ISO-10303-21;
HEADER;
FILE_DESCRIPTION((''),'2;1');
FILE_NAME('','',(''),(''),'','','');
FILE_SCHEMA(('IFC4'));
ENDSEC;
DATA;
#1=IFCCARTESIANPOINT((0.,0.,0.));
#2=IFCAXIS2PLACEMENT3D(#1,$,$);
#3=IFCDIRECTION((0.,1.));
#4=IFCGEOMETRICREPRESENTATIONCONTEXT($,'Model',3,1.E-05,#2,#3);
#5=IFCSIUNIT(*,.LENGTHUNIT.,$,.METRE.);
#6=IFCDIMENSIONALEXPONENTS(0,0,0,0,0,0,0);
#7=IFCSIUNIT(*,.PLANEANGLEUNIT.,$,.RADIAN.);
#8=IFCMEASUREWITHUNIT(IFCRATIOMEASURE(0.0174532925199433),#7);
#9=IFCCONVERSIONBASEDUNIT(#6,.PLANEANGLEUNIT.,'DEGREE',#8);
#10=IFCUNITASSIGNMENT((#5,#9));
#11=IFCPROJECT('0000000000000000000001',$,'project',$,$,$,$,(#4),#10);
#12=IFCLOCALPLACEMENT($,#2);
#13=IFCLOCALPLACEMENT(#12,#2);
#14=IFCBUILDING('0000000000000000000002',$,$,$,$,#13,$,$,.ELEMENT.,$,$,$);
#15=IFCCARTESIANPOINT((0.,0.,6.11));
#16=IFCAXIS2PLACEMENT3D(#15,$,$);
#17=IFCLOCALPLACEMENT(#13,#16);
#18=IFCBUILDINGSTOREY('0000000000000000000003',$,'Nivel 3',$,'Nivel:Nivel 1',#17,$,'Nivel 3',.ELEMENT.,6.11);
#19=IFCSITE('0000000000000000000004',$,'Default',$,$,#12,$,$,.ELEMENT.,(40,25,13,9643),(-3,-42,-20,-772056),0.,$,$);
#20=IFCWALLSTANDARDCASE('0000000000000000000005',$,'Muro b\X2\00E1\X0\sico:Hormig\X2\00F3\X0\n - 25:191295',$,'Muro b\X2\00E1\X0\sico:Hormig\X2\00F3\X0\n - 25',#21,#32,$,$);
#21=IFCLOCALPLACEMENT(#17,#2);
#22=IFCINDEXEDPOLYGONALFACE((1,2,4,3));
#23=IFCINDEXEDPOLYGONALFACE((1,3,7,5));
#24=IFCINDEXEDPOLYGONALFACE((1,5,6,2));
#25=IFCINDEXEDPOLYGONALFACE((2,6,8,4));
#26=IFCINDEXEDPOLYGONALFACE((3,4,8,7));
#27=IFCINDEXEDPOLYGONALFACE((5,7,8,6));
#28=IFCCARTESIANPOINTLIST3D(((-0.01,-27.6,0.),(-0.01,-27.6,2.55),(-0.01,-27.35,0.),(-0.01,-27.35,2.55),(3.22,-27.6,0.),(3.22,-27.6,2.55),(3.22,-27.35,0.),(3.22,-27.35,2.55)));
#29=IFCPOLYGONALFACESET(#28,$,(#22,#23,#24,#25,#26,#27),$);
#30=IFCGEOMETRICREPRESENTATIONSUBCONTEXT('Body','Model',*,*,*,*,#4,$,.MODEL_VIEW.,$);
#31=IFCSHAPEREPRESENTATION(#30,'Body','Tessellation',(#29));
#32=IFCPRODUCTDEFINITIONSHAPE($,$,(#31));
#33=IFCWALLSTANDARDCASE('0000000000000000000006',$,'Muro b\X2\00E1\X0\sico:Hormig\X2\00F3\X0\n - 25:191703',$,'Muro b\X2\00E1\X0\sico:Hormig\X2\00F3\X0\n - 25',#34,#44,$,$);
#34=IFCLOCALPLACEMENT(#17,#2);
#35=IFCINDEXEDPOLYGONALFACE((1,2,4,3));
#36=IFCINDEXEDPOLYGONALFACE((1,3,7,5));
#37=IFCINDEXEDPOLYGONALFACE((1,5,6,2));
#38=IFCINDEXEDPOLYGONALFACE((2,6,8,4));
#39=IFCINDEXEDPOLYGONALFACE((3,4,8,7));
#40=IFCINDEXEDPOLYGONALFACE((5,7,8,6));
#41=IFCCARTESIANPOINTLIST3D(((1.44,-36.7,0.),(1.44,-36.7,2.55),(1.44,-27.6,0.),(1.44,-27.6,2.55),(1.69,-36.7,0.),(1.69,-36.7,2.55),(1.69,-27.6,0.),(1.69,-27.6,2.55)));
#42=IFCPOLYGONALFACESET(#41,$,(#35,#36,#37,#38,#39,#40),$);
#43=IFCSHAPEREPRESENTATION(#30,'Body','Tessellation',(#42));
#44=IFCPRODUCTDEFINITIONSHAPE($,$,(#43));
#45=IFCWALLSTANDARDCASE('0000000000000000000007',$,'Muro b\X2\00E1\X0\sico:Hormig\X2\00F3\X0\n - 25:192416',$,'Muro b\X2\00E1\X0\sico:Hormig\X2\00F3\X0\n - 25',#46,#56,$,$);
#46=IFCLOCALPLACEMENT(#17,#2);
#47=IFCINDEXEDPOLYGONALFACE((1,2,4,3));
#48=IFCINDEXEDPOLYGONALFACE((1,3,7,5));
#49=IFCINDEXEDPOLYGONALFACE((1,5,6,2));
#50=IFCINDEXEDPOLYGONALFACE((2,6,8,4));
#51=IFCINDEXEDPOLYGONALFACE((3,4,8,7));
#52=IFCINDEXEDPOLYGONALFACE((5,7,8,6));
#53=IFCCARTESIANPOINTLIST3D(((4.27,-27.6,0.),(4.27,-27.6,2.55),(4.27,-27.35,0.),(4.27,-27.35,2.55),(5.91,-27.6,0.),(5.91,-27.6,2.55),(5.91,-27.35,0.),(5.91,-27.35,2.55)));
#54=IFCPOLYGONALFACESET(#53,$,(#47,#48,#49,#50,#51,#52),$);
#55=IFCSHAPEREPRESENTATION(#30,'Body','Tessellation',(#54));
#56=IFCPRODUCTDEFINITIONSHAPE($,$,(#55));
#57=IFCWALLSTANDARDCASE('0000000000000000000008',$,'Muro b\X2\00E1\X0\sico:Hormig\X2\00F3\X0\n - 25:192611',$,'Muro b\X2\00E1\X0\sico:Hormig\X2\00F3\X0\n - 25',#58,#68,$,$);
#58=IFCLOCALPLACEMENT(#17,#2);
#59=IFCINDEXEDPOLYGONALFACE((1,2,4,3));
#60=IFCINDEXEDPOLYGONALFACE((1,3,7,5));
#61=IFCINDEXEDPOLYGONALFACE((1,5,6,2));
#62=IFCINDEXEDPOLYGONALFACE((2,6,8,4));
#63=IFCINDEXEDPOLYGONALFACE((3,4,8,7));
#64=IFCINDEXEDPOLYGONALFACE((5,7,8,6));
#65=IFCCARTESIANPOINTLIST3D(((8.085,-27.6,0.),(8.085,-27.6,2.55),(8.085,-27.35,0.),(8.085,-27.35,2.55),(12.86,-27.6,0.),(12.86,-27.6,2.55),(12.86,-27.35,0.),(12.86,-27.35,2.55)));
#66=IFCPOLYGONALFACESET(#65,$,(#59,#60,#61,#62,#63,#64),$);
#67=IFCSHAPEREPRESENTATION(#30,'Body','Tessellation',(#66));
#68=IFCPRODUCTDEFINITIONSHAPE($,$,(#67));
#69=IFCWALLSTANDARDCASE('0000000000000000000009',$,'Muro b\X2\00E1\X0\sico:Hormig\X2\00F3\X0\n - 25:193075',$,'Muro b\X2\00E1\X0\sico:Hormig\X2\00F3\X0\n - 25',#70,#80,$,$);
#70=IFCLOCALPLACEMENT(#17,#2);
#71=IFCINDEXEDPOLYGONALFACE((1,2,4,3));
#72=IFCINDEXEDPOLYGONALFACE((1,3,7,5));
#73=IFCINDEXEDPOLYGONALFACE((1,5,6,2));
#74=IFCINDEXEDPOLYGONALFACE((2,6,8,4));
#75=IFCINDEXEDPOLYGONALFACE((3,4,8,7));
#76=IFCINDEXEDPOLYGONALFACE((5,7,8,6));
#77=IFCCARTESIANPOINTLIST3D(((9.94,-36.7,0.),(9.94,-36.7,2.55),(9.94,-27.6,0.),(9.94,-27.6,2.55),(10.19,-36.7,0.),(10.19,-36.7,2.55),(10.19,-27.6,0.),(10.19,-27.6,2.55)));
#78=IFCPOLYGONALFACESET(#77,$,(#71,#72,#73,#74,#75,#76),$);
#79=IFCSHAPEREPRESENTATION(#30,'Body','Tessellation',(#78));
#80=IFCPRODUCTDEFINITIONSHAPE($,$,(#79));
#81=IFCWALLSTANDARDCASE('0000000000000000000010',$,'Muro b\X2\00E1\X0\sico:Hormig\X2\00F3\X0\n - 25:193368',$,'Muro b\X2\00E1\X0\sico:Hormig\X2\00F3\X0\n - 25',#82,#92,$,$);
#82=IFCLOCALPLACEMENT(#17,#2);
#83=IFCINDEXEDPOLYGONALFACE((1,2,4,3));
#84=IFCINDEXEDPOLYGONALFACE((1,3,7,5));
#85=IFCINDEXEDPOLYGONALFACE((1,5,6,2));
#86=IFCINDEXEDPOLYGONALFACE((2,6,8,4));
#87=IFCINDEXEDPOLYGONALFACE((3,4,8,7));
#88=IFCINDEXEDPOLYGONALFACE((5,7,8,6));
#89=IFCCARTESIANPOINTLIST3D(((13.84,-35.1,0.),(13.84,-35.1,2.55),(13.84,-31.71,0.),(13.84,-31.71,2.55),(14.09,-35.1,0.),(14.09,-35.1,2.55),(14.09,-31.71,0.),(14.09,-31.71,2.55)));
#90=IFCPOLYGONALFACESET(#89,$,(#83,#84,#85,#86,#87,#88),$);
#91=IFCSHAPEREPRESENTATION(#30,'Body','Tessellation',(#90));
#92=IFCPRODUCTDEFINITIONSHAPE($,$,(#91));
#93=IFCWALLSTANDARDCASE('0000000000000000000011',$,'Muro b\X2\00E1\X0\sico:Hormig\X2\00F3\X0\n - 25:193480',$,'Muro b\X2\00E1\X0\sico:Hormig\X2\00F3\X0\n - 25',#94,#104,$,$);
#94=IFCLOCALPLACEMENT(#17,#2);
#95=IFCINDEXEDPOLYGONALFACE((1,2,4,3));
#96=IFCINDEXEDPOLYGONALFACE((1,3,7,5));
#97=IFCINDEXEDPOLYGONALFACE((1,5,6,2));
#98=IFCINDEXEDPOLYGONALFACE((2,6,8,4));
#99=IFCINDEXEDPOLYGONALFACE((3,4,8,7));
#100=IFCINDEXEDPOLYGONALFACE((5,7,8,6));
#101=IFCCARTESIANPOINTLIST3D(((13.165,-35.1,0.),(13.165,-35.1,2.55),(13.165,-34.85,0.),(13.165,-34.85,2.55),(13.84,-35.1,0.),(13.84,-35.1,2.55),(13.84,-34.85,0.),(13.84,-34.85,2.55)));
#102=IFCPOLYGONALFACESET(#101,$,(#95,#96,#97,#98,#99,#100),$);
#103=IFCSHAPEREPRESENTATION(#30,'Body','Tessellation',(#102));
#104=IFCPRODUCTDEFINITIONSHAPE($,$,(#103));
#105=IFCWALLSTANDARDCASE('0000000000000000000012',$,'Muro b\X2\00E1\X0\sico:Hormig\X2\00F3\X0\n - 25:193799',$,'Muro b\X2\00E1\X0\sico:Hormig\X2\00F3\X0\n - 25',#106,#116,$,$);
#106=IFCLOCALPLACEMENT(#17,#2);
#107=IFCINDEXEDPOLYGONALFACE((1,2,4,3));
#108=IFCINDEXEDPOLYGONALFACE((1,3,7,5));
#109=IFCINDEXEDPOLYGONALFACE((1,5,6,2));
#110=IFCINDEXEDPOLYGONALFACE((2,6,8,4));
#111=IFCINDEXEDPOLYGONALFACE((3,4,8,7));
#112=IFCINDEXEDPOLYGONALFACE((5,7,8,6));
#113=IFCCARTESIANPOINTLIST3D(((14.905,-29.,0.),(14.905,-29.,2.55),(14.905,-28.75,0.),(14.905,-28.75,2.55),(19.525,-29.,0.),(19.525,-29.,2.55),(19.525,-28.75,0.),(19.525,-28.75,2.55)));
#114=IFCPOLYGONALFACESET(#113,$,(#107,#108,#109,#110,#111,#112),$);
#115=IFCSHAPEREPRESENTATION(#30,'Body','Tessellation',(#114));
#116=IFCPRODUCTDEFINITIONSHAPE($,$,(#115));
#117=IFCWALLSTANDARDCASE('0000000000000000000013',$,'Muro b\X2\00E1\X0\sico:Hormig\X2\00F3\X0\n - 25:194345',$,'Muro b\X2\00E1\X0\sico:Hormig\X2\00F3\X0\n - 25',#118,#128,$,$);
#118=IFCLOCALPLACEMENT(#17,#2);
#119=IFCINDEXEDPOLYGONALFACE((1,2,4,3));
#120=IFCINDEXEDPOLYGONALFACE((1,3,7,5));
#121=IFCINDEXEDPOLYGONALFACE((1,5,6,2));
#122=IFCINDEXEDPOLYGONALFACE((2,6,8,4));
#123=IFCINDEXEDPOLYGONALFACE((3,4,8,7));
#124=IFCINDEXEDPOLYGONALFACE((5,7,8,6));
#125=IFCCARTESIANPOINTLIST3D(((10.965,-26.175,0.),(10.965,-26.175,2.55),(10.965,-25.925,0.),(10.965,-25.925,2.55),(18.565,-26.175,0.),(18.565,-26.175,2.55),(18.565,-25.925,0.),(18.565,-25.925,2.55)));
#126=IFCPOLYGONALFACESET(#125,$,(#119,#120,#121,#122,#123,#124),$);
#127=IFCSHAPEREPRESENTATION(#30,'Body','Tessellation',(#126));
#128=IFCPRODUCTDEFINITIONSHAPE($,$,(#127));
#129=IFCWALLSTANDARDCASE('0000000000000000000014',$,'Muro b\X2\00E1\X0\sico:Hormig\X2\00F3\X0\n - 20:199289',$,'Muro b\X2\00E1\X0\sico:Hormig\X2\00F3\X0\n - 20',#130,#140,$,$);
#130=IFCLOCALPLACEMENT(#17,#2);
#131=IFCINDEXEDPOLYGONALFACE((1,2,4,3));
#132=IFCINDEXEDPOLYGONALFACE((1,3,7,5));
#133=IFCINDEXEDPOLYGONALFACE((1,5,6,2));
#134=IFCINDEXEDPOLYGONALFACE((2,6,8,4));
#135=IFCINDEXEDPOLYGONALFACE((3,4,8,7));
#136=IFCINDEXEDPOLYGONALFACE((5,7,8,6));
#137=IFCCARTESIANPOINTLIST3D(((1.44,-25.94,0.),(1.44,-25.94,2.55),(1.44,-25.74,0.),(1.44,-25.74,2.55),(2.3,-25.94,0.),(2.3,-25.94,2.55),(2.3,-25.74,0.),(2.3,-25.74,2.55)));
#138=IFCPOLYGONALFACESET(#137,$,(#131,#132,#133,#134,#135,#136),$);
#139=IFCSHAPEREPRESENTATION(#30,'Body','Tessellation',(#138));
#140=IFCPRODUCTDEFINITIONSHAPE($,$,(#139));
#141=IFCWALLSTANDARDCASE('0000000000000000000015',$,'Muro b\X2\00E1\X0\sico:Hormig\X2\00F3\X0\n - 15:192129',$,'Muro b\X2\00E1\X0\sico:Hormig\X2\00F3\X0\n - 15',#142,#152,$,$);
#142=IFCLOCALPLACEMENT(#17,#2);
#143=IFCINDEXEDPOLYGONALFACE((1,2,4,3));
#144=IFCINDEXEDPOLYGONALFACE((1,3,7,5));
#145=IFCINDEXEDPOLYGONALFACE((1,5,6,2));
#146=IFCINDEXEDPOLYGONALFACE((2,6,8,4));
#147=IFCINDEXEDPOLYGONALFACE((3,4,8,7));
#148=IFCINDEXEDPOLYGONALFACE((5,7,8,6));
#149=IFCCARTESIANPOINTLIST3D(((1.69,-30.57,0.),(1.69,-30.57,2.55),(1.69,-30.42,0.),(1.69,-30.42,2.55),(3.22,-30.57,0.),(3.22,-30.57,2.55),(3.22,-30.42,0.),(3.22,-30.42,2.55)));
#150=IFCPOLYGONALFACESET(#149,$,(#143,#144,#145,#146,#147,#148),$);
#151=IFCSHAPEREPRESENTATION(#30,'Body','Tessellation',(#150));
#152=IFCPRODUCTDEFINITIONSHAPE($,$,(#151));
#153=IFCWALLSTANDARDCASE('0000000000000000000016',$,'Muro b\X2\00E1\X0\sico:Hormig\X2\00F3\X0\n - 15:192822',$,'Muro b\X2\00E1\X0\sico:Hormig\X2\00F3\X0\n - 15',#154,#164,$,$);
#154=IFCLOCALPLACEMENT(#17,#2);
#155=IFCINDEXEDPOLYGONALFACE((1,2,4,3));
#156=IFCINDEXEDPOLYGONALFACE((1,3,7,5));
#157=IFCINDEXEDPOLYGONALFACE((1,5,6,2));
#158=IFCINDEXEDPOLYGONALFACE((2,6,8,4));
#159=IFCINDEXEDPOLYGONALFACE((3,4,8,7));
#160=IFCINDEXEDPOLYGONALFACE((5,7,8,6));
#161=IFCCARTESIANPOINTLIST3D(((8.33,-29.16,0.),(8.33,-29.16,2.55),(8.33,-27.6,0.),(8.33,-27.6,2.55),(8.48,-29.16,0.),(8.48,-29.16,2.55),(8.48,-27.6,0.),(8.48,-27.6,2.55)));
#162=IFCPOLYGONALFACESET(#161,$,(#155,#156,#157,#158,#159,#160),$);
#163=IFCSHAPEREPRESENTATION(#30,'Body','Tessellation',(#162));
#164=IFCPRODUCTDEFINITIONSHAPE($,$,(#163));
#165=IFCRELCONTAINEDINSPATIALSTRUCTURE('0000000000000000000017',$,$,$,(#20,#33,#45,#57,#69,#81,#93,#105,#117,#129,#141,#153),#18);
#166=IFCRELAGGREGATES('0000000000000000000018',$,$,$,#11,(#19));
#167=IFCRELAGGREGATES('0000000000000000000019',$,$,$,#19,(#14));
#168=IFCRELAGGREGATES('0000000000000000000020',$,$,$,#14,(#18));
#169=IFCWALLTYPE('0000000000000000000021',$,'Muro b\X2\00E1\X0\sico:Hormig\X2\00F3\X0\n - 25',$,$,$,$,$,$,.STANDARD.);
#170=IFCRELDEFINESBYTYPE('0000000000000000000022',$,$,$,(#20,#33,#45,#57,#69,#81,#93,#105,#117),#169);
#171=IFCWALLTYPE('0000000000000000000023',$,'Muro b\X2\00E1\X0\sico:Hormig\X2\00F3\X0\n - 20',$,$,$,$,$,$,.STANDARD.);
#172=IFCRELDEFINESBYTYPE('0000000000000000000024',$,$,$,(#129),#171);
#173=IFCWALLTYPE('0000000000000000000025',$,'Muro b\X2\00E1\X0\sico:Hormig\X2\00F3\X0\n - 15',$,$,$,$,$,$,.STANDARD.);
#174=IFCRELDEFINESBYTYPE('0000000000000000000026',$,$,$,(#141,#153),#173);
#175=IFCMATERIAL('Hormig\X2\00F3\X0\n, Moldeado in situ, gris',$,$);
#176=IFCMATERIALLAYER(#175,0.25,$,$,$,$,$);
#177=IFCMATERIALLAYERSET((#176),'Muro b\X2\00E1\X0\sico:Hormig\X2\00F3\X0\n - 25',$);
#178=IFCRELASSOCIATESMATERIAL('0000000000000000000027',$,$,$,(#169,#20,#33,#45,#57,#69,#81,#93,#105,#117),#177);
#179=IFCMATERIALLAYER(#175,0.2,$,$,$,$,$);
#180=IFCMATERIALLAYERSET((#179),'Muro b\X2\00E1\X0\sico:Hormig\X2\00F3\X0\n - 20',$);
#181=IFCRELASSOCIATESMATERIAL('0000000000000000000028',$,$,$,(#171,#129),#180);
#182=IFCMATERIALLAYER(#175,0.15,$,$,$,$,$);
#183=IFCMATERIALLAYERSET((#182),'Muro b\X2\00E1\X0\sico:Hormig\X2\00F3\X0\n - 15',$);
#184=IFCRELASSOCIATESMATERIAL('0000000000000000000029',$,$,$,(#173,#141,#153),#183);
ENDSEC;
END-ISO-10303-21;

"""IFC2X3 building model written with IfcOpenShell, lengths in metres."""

from ifc_helpers import new_model, entity, si_unit, converted_unit, direction, frame, frame_2d, origin, place, context, subcontext, project, spatial, rectangle, extrude, material, layer, layer_set, layer_usage, type_object, element, save


model = new_model("IFC2X3")

# Units and contexts
model_context = context("Model", 3, precision=1e-05, world=origin(), true_north=direction((0.0, 1.0)))
body_context = subcontext(model_context, "Body", "Model", "MODEL_VIEW")
ifc_project = project(units=[si_unit("LENGTHUNIT", "METRE"), converted_unit("PLANEANGLEUNIT", "DEGREE", entity("IfcRatioMeasure", 0.0174532925199433), si_unit("PLANEANGLEUNIT", "RADIAN"), dimensions=[0, 0, 0, 0, 0, 0, 0])], contexts=[model_context])

# Site, building, storey
site_placement = place(None, origin())
site = spatial("IfcSite", under=ifc_project, at=site_placement, Name="Default", CompositionType="ELEMENT", RefLatitude=(40, 25, 13, 9643), RefLongitude=(-3, -42, -20, -772056), RefElevation=0.0)
building_placement = place(site_placement, origin())
building = spatial("IfcBuilding", under=site, at=building_placement, CompositionType="ELEMENT")
storey_placement = place(building_placement, frame((0.0, 0.0, 6.11)))
storey = spatial("IfcBuildingStorey", under=building, at=storey_placement, Name="Nivel 3", ObjectType="Nivel:Nivel 1", LongName="Nivel 3", CompositionType="ELEMENT", Elevation=6.11)

# Walls
ifc_material = material(Name="Hormigón, Moldeado in situ, gris")
ifc_layer_1 = layer(ifc_material, 0.25)
ifc_layer_set_1 = layer_set([ifc_layer_1], Name="Muro básico:Hormigón - 25")
wall_type_1 = type_object("IfcWallType", Name="Muro básico:Hormigón - 25", PredefinedType="STANDARD", material=ifc_layer_set_1)
ifc_layer_usage_1 = layer_usage(ifc_layer_set_1, "AXIS2", "NEGATIVE", 0.125)
wall_1_placement = place(storey_placement, frame((-0.01, -27.475, 0.0)))
element("IfcWallStandardCase", 1, at=wall_1_placement, inside=storey, type_object=wall_type_1, material=ifc_layer_usage_1, Name="Muro básico:Hormigón - 25:191295", ObjectType="Muro básico:Hormigón - 25", context=body_context, shape_type="SweptSolid", body=[
    extrude(rectangle(XDim=3.23, YDim=0.25, at=frame_2d((1.615, 0.0), x_axis=(-1.0, 0.0))), origin(), (0.0, 0.0, 1.0), 2.55),
])
ifc_layer_usage_2 = layer_usage(ifc_layer_set_1, "AXIS2", "NEGATIVE", 0.125)
wall_2_placement = place(storey_placement, frame((1.565, -27.6, 0.0), z_axis=(0.0, 0.0, 1.0), x_axis=(0.0, -1.0, 0.0)))
element("IfcWallStandardCase", 2, at=wall_2_placement, inside=storey, type_object=wall_type_1, material=ifc_layer_usage_2, Name="Muro básico:Hormigón - 25:191703", ObjectType="Muro básico:Hormigón - 25", context=body_context, shape_type="SweptSolid", body=[
    extrude(rectangle(XDim=9.1, YDim=0.25, at=frame_2d((4.55, 0.0), x_axis=(-1.0, 0.0))), origin(), (0.0, 0.0, 1.0), 2.55),
])
ifc_layer_usage_3 = layer_usage(ifc_layer_set_1, "AXIS2", "NEGATIVE", 0.125)
wall_3_placement = place(storey_placement, frame((4.27, -27.475, 0.0)))
element("IfcWallStandardCase", 3, at=wall_3_placement, inside=storey, type_object=wall_type_1, material=ifc_layer_usage_3, Name="Muro básico:Hormigón - 25:192416", ObjectType="Muro básico:Hormigón - 25", context=body_context, shape_type="SweptSolid", body=[
    extrude(rectangle(XDim=1.64, YDim=0.25, at=frame_2d((0.82, 0.0), x_axis=(-1.0, 0.0))), origin(), (0.0, 0.0, 1.0), 2.55),
])
ifc_layer_usage_4 = layer_usage(ifc_layer_set_1, "AXIS2", "NEGATIVE", 0.125)
wall_4_placement = place(storey_placement, frame((8.085, -27.475, 0.0)))
element("IfcWallStandardCase", 4, at=wall_4_placement, inside=storey, type_object=wall_type_1, material=ifc_layer_usage_4, Name="Muro básico:Hormigón - 25:192611", ObjectType="Muro básico:Hormigón - 25", context=body_context, shape_type="SweptSolid", body=[
    extrude(rectangle(XDim=4.775, YDim=0.25, at=frame_2d((2.3875, 0.0), x_axis=(-1.0, 0.0))), origin(), (0.0, 0.0, 1.0), 2.55),
])
ifc_layer_usage_5 = layer_usage(ifc_layer_set_1, "AXIS2", "NEGATIVE", 0.125)
wall_5_placement = place(storey_placement, frame((10.065, -27.6, 0.0), z_axis=(0.0, 0.0, 1.0), x_axis=(0.0, -1.0, 0.0)))
element("IfcWallStandardCase", 5, at=wall_5_placement, inside=storey, type_object=wall_type_1, material=ifc_layer_usage_5, Name="Muro básico:Hormigón - 25:193075", ObjectType="Muro básico:Hormigón - 25", context=body_context, shape_type="SweptSolid", body=[
    extrude(rectangle(XDim=9.1, YDim=0.25, at=frame_2d((4.55, 0.0), x_axis=(-1.0, 0.0))), origin(), (0.0, 0.0, 1.0), 2.55),
])
ifc_layer_usage_6 = layer_usage(ifc_layer_set_1, "AXIS2", "NEGATIVE", 0.125)
wall_6_placement = place(storey_placement, frame((13.965, -31.71, 0.0), z_axis=(0.0, 0.0, 1.0), x_axis=(0.0, -1.0, 0.0)))
element("IfcWallStandardCase", 6, at=wall_6_placement, inside=storey, type_object=wall_type_1, material=ifc_layer_usage_6, Name="Muro básico:Hormigón - 25:193368", ObjectType="Muro básico:Hormigón - 25", context=body_context, shape_type="SweptSolid", body=[
    extrude(rectangle(XDim=3.39, YDim=0.25, at=frame_2d((1.695, 0.0), x_axis=(-1.0, 0.0))), origin(), (0.0, 0.0, 1.0), 2.55),
])
ifc_layer_usage_7 = layer_usage(ifc_layer_set_1, "AXIS2", "NEGATIVE", 0.125)
wall_7_placement = place(storey_placement, frame((13.165, -34.975, 0.0)))
element("IfcWallStandardCase", 7, at=wall_7_placement, inside=storey, type_object=wall_type_1, material=ifc_layer_usage_7, Name="Muro básico:Hormigón - 25:193480", ObjectType="Muro básico:Hormigón - 25", context=body_context, shape_type="SweptSolid", body=[
    extrude(rectangle(XDim=0.675, YDim=0.25, at=frame_2d((0.3375, 0.0), x_axis=(-1.0, 0.0))), origin(), (0.0, 0.0, 1.0), 2.55),
])
ifc_layer_usage_8 = layer_usage(ifc_layer_set_1, "AXIS2", "NEGATIVE", 0.125)
wall_8_placement = place(storey_placement, frame((14.905, -28.875, 0.0)))
element("IfcWallStandardCase", 8, at=wall_8_placement, inside=storey, type_object=wall_type_1, material=ifc_layer_usage_8, Name="Muro básico:Hormigón - 25:193799", ObjectType="Muro básico:Hormigón - 25", context=body_context, shape_type="SweptSolid", body=[
    extrude(rectangle(XDim=4.62, YDim=0.25, at=frame_2d((2.31, 0.0), x_axis=(-1.0, 0.0))), origin(), (0.0, 0.0, 1.0), 2.55),
])
ifc_layer_usage_9 = layer_usage(ifc_layer_set_1, "AXIS2", "NEGATIVE", 0.125)
wall_9_placement = place(storey_placement, frame((18.565, -26.05, 0.0), z_axis=(0.0, 0.0, 1.0), x_axis=(-1.0, 0.0, 0.0)))
element("IfcWallStandardCase", 9, at=wall_9_placement, inside=storey, type_object=wall_type_1, material=ifc_layer_usage_9, Name="Muro básico:Hormigón - 25:194345", ObjectType="Muro básico:Hormigón - 25", context=body_context, shape_type="SweptSolid", body=[
    extrude(rectangle(XDim=7.6, YDim=0.25, at=frame_2d((3.8, 0.0), x_axis=(-1.0, 0.0))), origin(), (0.0, 0.0, 1.0), 2.55),
])
ifc_layer_2 = layer(ifc_material, 0.2)
ifc_layer_set_2 = layer_set([ifc_layer_2], Name="Muro básico:Hormigón - 20")
ifc_layer_usage_10 = layer_usage(ifc_layer_set_2, "AXIS2", "NEGATIVE", 0.1)
wall_type_2 = type_object("IfcWallType", Name="Muro básico:Hormigón - 20", PredefinedType="STANDARD", material=ifc_layer_set_2)
wall_10_placement = place(storey_placement, frame((1.44, -25.84, 0.0)))
element("IfcWallStandardCase", 10, at=wall_10_placement, inside=storey, type_object=wall_type_2, material=ifc_layer_usage_10, Name="Muro básico:Hormigón - 20:199289", ObjectType="Muro básico:Hormigón - 20", context=body_context, shape_type="SweptSolid", body=[
    extrude(rectangle(XDim=0.86, YDim=0.2, at=frame_2d((0.43, 0.0), x_axis=(-1.0, 0.0))), origin(), (0.0, 0.0, 1.0), 2.55),
])
ifc_layer_3 = layer(ifc_material, 0.15)
ifc_layer_set_3 = layer_set([ifc_layer_3], Name="Muro básico:Hormigón - 15")
ifc_layer_usage_11 = layer_usage(ifc_layer_set_3, "AXIS2", "NEGATIVE", 0.075)
wall_type_3 = type_object("IfcWallType", Name="Muro básico:Hormigón - 15", PredefinedType="STANDARD", material=ifc_layer_set_3)
wall_11_placement = place(storey_placement, frame((1.69, -30.495, 0.0)))
element("IfcWallStandardCase", 11, at=wall_11_placement, inside=storey, type_object=wall_type_3, material=ifc_layer_usage_11, Name="Muro básico:Hormigón - 15:192129", ObjectType="Muro básico:Hormigón - 15", context=body_context, shape_type="SweptSolid", body=[
    extrude(rectangle(XDim=1.53, YDim=0.15, at=frame_2d((0.765, 0.0), x_axis=(-1.0, 0.0))), origin(), (0.0, 0.0, 1.0), 2.55),
])
ifc_layer_usage_12 = layer_usage(ifc_layer_set_3, "AXIS2", "NEGATIVE", 0.075)
wall_12_placement = place(storey_placement, frame((8.405, -27.6, 0.0), z_axis=(0.0, 0.0, 1.0), x_axis=(0.0, -1.0, 0.0)))
element("IfcWallStandardCase", 12, at=wall_12_placement, inside=storey, type_object=wall_type_3, material=ifc_layer_usage_12, Name="Muro básico:Hormigón - 15:192822", ObjectType="Muro básico:Hormigón - 15", context=body_context, shape_type="SweptSolid", body=[
    extrude(rectangle(XDim=1.56, YDim=0.15, at=frame_2d((0.78, 0.0), x_axis=(-1.0, 0.0))), origin(), (0.0, 0.0, 1.0), 2.55),
])

save(model, "model.ifc")
